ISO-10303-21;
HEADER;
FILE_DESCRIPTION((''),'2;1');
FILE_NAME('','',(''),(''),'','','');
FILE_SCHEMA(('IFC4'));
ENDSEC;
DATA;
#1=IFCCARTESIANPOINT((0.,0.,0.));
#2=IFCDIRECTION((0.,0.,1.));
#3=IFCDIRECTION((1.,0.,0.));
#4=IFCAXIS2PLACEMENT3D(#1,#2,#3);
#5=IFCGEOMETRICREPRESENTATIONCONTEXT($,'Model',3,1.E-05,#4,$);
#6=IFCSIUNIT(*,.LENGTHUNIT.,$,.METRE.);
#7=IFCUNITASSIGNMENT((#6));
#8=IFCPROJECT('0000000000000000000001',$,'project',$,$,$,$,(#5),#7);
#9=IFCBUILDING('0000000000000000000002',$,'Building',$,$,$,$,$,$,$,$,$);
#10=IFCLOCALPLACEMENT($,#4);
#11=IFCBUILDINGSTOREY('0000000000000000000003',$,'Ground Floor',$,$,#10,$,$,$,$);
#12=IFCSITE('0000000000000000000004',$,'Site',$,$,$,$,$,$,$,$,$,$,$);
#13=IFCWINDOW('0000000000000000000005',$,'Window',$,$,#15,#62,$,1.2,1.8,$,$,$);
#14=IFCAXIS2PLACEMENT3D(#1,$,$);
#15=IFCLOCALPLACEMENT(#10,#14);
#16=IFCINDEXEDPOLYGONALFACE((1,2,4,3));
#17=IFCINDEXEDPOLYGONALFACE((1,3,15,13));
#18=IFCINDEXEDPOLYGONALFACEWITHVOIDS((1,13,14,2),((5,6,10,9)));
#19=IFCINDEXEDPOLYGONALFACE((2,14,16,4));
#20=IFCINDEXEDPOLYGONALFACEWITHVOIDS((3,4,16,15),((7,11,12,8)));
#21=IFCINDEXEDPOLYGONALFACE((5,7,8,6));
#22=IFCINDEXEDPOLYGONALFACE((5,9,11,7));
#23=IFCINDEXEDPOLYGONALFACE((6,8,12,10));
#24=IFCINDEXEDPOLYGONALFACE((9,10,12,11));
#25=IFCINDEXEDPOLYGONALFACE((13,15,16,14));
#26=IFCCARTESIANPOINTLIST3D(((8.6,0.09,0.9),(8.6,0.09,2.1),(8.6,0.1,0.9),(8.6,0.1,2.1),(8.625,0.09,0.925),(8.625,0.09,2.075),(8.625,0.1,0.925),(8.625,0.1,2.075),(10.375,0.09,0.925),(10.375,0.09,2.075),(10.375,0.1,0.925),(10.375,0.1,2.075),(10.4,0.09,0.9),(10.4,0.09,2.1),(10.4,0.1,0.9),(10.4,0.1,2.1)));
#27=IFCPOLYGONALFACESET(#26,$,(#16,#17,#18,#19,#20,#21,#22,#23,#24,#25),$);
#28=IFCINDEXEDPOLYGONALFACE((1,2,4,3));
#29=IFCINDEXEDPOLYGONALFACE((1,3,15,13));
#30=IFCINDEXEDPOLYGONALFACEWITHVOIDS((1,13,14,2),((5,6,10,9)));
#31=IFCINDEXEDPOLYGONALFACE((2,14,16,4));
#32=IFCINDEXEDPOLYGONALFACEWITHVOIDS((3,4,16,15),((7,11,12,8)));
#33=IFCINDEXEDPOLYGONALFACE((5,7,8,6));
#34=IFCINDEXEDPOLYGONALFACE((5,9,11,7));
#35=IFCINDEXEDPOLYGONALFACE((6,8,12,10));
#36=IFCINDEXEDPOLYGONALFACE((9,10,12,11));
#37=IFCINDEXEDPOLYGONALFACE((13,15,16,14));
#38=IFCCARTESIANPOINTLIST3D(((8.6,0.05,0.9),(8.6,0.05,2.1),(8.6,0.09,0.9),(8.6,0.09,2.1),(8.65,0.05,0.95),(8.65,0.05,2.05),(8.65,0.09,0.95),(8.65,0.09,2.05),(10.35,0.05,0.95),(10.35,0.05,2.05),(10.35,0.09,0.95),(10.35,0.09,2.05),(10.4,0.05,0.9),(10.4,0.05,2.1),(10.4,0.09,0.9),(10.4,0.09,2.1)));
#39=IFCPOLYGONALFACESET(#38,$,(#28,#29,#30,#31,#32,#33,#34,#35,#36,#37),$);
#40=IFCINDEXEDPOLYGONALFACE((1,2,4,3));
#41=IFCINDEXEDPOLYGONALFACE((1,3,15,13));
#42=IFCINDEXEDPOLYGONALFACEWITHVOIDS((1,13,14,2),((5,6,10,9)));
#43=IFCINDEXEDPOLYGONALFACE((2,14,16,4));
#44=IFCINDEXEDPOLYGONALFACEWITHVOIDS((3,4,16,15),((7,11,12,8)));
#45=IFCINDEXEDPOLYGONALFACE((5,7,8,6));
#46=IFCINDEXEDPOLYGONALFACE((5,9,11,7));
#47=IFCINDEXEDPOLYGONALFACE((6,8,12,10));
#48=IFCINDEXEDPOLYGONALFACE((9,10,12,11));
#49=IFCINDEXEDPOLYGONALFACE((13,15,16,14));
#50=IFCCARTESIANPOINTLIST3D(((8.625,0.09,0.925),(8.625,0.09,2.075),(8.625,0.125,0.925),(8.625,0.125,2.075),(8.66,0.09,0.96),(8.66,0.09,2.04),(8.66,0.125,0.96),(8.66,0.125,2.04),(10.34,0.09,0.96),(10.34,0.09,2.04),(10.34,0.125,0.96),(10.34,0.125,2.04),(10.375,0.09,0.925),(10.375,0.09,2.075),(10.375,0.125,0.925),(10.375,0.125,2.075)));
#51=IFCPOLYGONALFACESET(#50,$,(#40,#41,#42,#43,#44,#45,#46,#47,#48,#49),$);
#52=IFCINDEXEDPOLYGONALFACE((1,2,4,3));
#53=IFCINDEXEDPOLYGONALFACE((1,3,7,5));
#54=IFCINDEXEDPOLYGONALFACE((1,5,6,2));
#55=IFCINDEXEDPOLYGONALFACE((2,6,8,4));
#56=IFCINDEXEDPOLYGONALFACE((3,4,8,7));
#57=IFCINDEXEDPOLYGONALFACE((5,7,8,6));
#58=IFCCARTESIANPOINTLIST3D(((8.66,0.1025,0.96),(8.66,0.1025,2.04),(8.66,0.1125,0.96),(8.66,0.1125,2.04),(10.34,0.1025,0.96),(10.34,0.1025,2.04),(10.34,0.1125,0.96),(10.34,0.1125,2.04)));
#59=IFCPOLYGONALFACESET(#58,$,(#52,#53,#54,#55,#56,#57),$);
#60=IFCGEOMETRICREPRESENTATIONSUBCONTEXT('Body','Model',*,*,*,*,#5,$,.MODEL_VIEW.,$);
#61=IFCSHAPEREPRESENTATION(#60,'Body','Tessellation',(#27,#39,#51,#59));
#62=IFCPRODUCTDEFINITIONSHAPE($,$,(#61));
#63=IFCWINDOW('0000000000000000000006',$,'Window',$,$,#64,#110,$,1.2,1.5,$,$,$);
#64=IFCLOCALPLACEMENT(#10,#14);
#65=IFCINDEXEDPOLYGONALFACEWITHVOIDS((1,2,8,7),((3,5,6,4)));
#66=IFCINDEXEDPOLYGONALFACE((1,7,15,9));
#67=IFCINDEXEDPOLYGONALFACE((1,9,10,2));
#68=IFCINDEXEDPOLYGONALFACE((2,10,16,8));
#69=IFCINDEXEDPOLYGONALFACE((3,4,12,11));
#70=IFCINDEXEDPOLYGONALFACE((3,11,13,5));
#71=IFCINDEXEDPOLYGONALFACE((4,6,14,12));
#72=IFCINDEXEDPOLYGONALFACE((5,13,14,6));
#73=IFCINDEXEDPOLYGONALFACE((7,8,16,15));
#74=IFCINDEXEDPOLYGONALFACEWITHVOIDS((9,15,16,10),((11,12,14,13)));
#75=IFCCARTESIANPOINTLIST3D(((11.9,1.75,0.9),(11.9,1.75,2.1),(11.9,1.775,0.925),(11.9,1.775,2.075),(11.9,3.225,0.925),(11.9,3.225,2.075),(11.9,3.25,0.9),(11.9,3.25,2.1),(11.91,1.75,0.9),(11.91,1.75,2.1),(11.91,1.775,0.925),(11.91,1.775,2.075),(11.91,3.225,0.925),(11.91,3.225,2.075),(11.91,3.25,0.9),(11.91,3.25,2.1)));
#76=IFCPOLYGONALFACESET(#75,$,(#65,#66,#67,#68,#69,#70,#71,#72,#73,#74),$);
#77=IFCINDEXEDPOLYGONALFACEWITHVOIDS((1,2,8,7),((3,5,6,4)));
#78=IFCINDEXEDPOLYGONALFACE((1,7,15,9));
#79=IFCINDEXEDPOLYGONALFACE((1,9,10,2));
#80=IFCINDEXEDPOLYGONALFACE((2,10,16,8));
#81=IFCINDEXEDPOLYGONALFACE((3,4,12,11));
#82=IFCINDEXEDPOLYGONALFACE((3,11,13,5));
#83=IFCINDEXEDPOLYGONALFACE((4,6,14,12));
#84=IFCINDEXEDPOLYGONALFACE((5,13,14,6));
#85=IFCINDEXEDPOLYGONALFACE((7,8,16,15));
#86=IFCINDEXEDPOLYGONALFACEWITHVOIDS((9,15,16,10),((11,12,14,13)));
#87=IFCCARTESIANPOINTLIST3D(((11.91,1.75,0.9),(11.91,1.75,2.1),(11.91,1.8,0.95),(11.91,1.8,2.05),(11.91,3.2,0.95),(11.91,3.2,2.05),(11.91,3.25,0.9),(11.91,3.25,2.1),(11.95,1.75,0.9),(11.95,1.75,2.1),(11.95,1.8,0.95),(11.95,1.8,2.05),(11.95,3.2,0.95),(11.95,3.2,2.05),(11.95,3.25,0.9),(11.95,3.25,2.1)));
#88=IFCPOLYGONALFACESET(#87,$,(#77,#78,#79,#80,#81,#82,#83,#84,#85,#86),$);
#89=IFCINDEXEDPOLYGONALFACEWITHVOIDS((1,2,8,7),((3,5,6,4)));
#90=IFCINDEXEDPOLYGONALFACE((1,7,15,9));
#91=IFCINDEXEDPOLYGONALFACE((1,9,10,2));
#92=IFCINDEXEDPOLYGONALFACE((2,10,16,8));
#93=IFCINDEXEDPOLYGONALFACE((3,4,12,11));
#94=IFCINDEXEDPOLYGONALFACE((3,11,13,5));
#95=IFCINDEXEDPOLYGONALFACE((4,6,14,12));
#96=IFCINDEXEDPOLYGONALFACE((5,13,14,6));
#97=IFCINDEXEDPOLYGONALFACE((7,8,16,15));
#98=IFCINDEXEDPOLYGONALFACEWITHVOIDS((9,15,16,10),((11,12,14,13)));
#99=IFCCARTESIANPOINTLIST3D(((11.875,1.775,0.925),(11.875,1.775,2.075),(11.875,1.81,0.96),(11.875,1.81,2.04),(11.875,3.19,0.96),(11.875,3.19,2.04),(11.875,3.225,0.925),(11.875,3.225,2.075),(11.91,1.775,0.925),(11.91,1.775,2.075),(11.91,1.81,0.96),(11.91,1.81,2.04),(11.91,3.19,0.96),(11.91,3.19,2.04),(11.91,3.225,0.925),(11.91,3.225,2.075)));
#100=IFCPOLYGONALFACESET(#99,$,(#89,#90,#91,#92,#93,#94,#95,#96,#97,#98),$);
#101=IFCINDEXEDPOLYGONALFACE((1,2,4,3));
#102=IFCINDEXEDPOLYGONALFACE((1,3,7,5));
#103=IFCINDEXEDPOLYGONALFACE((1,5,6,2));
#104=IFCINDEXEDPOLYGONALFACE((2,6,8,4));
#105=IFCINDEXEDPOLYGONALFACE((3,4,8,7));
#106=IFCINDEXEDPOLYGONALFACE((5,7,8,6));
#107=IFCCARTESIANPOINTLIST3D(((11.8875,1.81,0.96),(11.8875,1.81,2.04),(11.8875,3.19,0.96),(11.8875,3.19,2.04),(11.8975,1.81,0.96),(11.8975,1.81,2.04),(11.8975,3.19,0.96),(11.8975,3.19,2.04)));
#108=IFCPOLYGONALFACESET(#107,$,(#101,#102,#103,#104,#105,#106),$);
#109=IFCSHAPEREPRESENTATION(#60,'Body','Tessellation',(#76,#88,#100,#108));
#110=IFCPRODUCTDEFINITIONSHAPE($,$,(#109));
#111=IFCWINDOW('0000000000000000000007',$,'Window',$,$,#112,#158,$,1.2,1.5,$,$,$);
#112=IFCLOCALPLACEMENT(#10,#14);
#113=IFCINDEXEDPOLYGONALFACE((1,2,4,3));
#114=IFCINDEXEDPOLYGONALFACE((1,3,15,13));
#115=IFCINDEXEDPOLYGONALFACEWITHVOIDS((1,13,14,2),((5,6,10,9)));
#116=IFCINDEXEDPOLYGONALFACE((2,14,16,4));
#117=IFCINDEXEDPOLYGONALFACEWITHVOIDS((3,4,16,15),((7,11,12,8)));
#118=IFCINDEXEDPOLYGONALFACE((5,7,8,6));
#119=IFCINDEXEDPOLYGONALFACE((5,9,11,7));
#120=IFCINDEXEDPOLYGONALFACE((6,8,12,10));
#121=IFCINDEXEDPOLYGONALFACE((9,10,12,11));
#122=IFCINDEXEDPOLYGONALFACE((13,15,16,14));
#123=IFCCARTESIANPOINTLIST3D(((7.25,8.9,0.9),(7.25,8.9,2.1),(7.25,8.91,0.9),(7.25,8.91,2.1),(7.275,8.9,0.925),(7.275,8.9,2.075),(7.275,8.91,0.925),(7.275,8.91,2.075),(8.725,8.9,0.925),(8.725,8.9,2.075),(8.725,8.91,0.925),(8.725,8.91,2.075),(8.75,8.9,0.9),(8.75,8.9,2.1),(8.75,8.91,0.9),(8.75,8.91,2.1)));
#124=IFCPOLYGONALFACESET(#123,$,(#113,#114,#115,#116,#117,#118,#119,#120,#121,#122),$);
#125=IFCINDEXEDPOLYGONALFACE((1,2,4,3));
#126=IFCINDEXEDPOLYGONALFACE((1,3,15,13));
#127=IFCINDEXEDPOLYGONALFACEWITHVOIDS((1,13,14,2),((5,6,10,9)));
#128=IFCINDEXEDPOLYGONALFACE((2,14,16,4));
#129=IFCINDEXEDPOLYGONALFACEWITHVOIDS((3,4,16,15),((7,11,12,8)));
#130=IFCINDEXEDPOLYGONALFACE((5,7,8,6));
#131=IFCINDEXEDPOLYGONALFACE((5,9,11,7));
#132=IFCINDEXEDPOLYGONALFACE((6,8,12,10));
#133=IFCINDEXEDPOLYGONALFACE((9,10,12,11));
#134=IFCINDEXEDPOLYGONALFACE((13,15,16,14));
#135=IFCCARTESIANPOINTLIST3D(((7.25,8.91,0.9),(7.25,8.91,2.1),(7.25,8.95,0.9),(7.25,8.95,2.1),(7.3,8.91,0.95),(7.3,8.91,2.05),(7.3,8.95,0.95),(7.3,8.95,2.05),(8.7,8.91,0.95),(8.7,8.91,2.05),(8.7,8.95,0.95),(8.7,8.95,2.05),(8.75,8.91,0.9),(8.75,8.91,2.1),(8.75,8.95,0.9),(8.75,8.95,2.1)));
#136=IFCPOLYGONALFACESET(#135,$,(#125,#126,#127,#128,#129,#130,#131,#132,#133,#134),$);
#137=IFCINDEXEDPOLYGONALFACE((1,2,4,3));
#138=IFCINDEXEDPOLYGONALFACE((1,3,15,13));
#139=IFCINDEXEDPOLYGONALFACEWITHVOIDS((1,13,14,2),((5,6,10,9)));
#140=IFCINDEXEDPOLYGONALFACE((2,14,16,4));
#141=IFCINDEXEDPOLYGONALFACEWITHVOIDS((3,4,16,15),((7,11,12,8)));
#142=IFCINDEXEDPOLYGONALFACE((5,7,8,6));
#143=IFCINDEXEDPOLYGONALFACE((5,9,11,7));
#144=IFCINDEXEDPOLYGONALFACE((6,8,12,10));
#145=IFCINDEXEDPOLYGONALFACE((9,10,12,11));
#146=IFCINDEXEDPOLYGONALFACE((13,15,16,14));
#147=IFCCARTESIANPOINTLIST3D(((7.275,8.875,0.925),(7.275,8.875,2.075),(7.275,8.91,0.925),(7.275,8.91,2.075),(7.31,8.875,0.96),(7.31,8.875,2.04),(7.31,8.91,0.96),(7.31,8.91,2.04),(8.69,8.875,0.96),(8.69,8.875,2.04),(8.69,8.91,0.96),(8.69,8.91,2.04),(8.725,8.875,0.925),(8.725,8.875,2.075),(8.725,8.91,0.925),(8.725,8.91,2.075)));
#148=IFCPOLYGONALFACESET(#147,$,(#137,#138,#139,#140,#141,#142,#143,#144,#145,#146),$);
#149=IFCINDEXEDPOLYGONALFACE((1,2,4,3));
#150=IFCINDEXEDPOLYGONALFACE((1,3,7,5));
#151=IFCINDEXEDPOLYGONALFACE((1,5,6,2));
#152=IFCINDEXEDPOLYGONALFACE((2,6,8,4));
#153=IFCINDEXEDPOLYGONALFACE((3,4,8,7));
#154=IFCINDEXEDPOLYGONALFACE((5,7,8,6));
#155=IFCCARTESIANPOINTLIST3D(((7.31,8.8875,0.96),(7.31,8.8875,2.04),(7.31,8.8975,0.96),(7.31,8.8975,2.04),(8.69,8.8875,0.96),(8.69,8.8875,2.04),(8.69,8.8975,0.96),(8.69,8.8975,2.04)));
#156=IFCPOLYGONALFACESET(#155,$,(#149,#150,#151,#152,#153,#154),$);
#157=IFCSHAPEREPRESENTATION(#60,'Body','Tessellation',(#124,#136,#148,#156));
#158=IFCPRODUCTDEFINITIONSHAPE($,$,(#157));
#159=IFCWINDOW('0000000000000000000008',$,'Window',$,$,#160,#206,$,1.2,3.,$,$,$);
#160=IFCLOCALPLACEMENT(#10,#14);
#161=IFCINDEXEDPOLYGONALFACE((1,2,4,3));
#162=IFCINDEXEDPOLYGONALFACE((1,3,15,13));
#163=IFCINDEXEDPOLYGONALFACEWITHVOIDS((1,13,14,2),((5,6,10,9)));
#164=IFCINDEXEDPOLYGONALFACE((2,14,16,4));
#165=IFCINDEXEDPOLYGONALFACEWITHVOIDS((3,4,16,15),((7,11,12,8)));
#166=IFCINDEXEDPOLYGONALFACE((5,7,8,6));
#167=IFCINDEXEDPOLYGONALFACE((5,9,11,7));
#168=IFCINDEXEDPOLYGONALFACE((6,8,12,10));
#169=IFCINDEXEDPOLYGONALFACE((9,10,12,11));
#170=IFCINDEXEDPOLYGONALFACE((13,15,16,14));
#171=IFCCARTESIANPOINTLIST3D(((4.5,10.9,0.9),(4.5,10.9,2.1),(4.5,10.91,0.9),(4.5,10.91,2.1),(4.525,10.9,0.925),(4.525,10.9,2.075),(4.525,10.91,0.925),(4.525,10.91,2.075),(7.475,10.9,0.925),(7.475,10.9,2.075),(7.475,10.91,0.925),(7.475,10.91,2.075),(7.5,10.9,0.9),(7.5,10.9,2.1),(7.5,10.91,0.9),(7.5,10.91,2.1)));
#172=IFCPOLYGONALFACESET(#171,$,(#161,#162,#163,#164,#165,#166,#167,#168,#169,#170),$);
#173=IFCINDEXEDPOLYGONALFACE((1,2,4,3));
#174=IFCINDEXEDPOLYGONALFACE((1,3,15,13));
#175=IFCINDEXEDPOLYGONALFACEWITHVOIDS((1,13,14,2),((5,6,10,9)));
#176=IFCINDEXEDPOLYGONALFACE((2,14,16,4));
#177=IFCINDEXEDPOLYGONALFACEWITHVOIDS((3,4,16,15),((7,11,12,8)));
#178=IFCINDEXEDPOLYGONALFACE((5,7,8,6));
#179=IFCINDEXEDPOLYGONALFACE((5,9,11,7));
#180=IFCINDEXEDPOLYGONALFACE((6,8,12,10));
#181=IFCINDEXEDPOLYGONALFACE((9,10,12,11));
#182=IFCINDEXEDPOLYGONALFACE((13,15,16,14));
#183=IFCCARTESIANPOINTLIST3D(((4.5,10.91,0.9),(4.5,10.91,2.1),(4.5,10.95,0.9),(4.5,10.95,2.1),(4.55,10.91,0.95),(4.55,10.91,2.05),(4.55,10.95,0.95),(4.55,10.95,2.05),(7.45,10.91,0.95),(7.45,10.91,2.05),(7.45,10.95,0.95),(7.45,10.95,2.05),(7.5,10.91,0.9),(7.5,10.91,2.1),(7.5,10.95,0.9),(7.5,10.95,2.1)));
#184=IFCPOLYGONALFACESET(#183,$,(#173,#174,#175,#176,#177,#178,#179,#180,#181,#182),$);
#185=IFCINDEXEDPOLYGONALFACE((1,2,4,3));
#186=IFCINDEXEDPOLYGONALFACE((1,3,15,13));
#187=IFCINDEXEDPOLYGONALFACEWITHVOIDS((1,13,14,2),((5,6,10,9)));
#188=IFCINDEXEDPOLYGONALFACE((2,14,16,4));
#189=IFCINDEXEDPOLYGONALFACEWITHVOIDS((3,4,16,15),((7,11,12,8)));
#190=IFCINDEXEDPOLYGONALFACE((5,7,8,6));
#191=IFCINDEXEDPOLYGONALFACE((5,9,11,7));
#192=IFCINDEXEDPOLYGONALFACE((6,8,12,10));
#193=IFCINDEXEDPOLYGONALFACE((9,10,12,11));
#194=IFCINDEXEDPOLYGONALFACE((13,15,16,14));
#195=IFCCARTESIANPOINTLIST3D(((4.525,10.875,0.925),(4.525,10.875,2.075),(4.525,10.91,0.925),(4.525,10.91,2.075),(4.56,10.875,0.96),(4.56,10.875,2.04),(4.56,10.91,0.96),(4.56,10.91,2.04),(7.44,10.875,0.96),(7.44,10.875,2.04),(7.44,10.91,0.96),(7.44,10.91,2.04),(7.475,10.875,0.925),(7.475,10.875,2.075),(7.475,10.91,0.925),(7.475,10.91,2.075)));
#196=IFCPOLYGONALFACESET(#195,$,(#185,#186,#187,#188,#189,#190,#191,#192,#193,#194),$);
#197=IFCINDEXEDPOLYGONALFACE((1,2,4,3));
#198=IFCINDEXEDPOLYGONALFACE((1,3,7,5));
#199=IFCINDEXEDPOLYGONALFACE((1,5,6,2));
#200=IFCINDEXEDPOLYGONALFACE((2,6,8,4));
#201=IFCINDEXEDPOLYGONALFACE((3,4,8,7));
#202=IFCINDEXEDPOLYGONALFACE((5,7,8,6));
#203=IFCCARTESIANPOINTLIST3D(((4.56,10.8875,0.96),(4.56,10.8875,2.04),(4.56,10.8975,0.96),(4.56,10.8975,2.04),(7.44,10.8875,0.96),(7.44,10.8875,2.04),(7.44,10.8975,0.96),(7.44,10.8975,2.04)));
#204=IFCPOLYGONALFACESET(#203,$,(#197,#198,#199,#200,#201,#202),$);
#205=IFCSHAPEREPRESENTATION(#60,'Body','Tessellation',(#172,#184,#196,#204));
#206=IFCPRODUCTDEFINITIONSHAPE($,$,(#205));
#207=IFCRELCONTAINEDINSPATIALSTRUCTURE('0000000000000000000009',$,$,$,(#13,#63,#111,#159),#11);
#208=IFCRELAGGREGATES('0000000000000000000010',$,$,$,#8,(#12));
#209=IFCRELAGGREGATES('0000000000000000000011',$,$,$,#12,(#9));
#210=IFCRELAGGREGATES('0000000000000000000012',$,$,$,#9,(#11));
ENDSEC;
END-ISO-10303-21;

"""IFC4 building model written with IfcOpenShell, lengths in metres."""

from ifc_helpers import new_model, si_unit, frame, origin_with_axes, place, context, subcontext, project, spatial, line, indexed_curve, outline, extrude, element, save


model = new_model("IFC4")

# Units and contexts
model_context = context("Model", 3, precision=1e-05, world=origin_with_axes())
body_context = subcontext(model_context, "Body", "Model", "MODEL_VIEW")
ifc_project = project(units=[si_unit("LENGTHUNIT", "METRE")], contexts=[model_context])

# Site, building, storey
site = spatial("IfcSite", under=ifc_project, Name="Site")
building = spatial("IfcBuilding", under=site, Name="Building")
storey_placement = place(None, origin_with_axes())
storey = spatial("IfcBuildingStorey", under=building, at=storey_placement, Name="Ground Floor")

# Windows
window_1_placement = place(storey_placement, frame((8.6, 0.0, 0.9), z_axis=(0.0, 0.0, 1.0), x_axis=(1.0, 0.0, 0.0)))
element("IfcWindow", 1, at=window_1_placement, inside=storey, Name="Window", OverallHeight=1.2, OverallWidth=1.8, context=body_context, shape_type="SweptSolid", body=[
    extrude(outline(indexed_curve([(0.0, 0.0), (1.8, 0.0), (1.8, 1.2), (0.0, 1.2)], segments=[line(1, 2, 3, 4, 1)]), holes=[indexed_curve([(0.025, 0.025), (1.775, 0.025), (1.775, 1.175), (0.025, 1.175)], segments=[line(1, 2, 3, 4, 1)])]), frame((0.0, 0.09, 0.0), z_axis=(0.0, -1.0, 0.0), x_axis=(1.0, 0.0, 0.0)), (0.0, 0.0, -1.0), 0.01),
    extrude(outline(indexed_curve([(0.0, 0.0), (1.8, 0.0), (1.8, 1.2), (0.0, 1.2)], segments=[line(1, 2, 3, 4, 1)]), holes=[indexed_curve([(0.05, 0.05), (1.75, 0.05), (1.75, 1.15), (0.05, 1.15)], segments=[line(1, 2, 3, 4, 1)])]), frame((0.0, 0.05, 0.0), z_axis=(0.0, -1.0, 0.0), x_axis=(1.0, 0.0, 0.0)), (0.0, 0.0, -1.0), 0.04),
    extrude(outline(indexed_curve([(0.0, 0.0), (1.75, 0.0), (1.75, 1.15), (0.0, 1.15)], segments=[line(1, 2, 3, 4, 1)]), holes=[indexed_curve([(0.035, 0.035), (1.715, 0.035), (1.715, 1.115), (0.035, 1.115)], segments=[line(1, 2, 3, 4, 1)])]), frame((0.025, 0.09, 0.025), z_axis=(0.0, -1.0, 0.0), x_axis=(1.0, 0.0, 0.0)), (0.0, 0.0, -1.0), 0.035),
    extrude(outline(indexed_curve([(0.035, 0.035), (1.715, 0.035), (1.715, 1.115), (0.035, 1.115)], segments=[line(1, 2, 3, 4, 1)])), frame((0.025, 0.1025, 0.025), z_axis=(0.0, -1.0, 0.0), x_axis=(1.0, 0.0, 0.0)), (0.0, 0.0, -1.0), 0.01),
])
for number, where, z_axis, x_axis, name in (
    (2, (12.0, 1.75, 0.9), (0.0, 0.0, 1.0), (0.0, 1.0, 0.0), "Window"),
    (3, (8.75, 9.0, 0.9), (0.0, 0.0, 1.0), (-1.0, 0.0, 0.0), "Window"),
):
    element("IfcWindow", number, at=place(storey_placement, frame(where, z_axis=z_axis, x_axis=x_axis)), inside=storey, Name=name, OverallHeight=1.2, OverallWidth=1.5, context=body_context, shape_type="SweptSolid", body=[
        extrude(outline(indexed_curve([(0.0, 0.0), (1.5, 0.0), (1.5, 1.2), (0.0, 1.2)], segments=[line(1, 2, 3, 4, 1)]), holes=[indexed_curve([(0.025, 0.025), (1.475, 0.025), (1.475, 1.175), (0.025, 1.175)], segments=[line(1, 2, 3, 4, 1)])]), frame((0.0, 0.09, 0.0), z_axis=(0.0, -1.0, 0.0), x_axis=(1.0, 0.0, 0.0)), (0.0, 0.0, -1.0), 0.01),
        extrude(outline(indexed_curve([(0.0, 0.0), (1.5, 0.0), (1.5, 1.2), (0.0, 1.2)], segments=[line(1, 2, 3, 4, 1)]), holes=[indexed_curve([(0.05, 0.05), (1.45, 0.05), (1.45, 1.15), (0.05, 1.15)], segments=[line(1, 2, 3, 4, 1)])]), frame((0.0, 0.05, 0.0), z_axis=(0.0, -1.0, 0.0), x_axis=(1.0, 0.0, 0.0)), (0.0, 0.0, -1.0), 0.04),
        extrude(outline(indexed_curve([(0.0, 0.0), (1.45, 0.0), (1.45, 1.15), (0.0, 1.15)], segments=[line(1, 2, 3, 4, 1)]), holes=[indexed_curve([(0.035, 0.035), (1.415, 0.035), (1.415, 1.115), (0.035, 1.115)], segments=[line(1, 2, 3, 4, 1)])]), frame((0.025, 0.09, 0.025), z_axis=(0.0, -1.0, 0.0), x_axis=(1.0, 0.0, 0.0)), (0.0, 0.0, -1.0), 0.035),
        extrude(outline(indexed_curve([(0.035, 0.035), (1.415, 0.035), (1.415, 1.115), (0.035, 1.115)], segments=[line(1, 2, 3, 4, 1)])), frame((0.025, 0.1025, 0.025), z_axis=(0.0, -1.0, 0.0), x_axis=(1.0, 0.0, 0.0)), (0.0, 0.0, -1.0), 0.01),
    ])
window_2_placement = place(storey_placement, frame((7.5, 11.0, 0.9), z_axis=(0.0, 0.0, 1.0), x_axis=(-1.0, 0.0, 0.0)))
element("IfcWindow", 4, at=window_2_placement, inside=storey, Name="Window", OverallHeight=1.2, OverallWidth=3.0, context=body_context, shape_type="SweptSolid", body=[
    extrude(outline(indexed_curve([(0.0, 0.0), (3.0, 0.0), (3.0, 1.2), (0.0, 1.2)], segments=[line(1, 2, 3, 4, 1)]), holes=[indexed_curve([(0.025, 0.025), (2.975, 0.025), (2.975, 1.175), (0.025, 1.175)], segments=[line(1, 2, 3, 4, 1)])]), frame((0.0, 0.09, 0.0), z_axis=(0.0, -1.0, 0.0), x_axis=(1.0, 0.0, 0.0)), (0.0, 0.0, -1.0), 0.01),
    extrude(outline(indexed_curve([(0.0, 0.0), (3.0, 0.0), (3.0, 1.2), (0.0, 1.2)], segments=[line(1, 2, 3, 4, 1)]), holes=[indexed_curve([(0.05, 0.05), (2.95, 0.05), (2.95, 1.15), (0.05, 1.15)], segments=[line(1, 2, 3, 4, 1)])]), frame((0.0, 0.05, 0.0), z_axis=(0.0, -1.0, 0.0), x_axis=(1.0, 0.0, 0.0)), (0.0, 0.0, -1.0), 0.04),
    extrude(outline(indexed_curve([(0.0, 0.0), (2.95, 0.0), (2.95, 1.15), (0.0, 1.15)], segments=[line(1, 2, 3, 4, 1)]), holes=[indexed_curve([(0.035, 0.035), (2.915, 0.035), (2.915, 1.115), (0.035, 1.115)], segments=[line(1, 2, 3, 4, 1)])]), frame((0.025, 0.09, 0.025), z_axis=(0.0, -1.0, 0.0), x_axis=(1.0, 0.0, 0.0)), (0.0, 0.0, -1.0), 0.035),
    extrude(outline(indexed_curve([(0.035, 0.035), (2.915, 0.035), (2.915, 1.115), (0.035, 1.115)], segments=[line(1, 2, 3, 4, 1)])), frame((0.025, 0.1025, 0.025), z_axis=(0.0, -1.0, 0.0), x_axis=(1.0, 0.0, 0.0)), (0.0, 0.0, -1.0), 0.01),
])

save(model, "model.ifc")
